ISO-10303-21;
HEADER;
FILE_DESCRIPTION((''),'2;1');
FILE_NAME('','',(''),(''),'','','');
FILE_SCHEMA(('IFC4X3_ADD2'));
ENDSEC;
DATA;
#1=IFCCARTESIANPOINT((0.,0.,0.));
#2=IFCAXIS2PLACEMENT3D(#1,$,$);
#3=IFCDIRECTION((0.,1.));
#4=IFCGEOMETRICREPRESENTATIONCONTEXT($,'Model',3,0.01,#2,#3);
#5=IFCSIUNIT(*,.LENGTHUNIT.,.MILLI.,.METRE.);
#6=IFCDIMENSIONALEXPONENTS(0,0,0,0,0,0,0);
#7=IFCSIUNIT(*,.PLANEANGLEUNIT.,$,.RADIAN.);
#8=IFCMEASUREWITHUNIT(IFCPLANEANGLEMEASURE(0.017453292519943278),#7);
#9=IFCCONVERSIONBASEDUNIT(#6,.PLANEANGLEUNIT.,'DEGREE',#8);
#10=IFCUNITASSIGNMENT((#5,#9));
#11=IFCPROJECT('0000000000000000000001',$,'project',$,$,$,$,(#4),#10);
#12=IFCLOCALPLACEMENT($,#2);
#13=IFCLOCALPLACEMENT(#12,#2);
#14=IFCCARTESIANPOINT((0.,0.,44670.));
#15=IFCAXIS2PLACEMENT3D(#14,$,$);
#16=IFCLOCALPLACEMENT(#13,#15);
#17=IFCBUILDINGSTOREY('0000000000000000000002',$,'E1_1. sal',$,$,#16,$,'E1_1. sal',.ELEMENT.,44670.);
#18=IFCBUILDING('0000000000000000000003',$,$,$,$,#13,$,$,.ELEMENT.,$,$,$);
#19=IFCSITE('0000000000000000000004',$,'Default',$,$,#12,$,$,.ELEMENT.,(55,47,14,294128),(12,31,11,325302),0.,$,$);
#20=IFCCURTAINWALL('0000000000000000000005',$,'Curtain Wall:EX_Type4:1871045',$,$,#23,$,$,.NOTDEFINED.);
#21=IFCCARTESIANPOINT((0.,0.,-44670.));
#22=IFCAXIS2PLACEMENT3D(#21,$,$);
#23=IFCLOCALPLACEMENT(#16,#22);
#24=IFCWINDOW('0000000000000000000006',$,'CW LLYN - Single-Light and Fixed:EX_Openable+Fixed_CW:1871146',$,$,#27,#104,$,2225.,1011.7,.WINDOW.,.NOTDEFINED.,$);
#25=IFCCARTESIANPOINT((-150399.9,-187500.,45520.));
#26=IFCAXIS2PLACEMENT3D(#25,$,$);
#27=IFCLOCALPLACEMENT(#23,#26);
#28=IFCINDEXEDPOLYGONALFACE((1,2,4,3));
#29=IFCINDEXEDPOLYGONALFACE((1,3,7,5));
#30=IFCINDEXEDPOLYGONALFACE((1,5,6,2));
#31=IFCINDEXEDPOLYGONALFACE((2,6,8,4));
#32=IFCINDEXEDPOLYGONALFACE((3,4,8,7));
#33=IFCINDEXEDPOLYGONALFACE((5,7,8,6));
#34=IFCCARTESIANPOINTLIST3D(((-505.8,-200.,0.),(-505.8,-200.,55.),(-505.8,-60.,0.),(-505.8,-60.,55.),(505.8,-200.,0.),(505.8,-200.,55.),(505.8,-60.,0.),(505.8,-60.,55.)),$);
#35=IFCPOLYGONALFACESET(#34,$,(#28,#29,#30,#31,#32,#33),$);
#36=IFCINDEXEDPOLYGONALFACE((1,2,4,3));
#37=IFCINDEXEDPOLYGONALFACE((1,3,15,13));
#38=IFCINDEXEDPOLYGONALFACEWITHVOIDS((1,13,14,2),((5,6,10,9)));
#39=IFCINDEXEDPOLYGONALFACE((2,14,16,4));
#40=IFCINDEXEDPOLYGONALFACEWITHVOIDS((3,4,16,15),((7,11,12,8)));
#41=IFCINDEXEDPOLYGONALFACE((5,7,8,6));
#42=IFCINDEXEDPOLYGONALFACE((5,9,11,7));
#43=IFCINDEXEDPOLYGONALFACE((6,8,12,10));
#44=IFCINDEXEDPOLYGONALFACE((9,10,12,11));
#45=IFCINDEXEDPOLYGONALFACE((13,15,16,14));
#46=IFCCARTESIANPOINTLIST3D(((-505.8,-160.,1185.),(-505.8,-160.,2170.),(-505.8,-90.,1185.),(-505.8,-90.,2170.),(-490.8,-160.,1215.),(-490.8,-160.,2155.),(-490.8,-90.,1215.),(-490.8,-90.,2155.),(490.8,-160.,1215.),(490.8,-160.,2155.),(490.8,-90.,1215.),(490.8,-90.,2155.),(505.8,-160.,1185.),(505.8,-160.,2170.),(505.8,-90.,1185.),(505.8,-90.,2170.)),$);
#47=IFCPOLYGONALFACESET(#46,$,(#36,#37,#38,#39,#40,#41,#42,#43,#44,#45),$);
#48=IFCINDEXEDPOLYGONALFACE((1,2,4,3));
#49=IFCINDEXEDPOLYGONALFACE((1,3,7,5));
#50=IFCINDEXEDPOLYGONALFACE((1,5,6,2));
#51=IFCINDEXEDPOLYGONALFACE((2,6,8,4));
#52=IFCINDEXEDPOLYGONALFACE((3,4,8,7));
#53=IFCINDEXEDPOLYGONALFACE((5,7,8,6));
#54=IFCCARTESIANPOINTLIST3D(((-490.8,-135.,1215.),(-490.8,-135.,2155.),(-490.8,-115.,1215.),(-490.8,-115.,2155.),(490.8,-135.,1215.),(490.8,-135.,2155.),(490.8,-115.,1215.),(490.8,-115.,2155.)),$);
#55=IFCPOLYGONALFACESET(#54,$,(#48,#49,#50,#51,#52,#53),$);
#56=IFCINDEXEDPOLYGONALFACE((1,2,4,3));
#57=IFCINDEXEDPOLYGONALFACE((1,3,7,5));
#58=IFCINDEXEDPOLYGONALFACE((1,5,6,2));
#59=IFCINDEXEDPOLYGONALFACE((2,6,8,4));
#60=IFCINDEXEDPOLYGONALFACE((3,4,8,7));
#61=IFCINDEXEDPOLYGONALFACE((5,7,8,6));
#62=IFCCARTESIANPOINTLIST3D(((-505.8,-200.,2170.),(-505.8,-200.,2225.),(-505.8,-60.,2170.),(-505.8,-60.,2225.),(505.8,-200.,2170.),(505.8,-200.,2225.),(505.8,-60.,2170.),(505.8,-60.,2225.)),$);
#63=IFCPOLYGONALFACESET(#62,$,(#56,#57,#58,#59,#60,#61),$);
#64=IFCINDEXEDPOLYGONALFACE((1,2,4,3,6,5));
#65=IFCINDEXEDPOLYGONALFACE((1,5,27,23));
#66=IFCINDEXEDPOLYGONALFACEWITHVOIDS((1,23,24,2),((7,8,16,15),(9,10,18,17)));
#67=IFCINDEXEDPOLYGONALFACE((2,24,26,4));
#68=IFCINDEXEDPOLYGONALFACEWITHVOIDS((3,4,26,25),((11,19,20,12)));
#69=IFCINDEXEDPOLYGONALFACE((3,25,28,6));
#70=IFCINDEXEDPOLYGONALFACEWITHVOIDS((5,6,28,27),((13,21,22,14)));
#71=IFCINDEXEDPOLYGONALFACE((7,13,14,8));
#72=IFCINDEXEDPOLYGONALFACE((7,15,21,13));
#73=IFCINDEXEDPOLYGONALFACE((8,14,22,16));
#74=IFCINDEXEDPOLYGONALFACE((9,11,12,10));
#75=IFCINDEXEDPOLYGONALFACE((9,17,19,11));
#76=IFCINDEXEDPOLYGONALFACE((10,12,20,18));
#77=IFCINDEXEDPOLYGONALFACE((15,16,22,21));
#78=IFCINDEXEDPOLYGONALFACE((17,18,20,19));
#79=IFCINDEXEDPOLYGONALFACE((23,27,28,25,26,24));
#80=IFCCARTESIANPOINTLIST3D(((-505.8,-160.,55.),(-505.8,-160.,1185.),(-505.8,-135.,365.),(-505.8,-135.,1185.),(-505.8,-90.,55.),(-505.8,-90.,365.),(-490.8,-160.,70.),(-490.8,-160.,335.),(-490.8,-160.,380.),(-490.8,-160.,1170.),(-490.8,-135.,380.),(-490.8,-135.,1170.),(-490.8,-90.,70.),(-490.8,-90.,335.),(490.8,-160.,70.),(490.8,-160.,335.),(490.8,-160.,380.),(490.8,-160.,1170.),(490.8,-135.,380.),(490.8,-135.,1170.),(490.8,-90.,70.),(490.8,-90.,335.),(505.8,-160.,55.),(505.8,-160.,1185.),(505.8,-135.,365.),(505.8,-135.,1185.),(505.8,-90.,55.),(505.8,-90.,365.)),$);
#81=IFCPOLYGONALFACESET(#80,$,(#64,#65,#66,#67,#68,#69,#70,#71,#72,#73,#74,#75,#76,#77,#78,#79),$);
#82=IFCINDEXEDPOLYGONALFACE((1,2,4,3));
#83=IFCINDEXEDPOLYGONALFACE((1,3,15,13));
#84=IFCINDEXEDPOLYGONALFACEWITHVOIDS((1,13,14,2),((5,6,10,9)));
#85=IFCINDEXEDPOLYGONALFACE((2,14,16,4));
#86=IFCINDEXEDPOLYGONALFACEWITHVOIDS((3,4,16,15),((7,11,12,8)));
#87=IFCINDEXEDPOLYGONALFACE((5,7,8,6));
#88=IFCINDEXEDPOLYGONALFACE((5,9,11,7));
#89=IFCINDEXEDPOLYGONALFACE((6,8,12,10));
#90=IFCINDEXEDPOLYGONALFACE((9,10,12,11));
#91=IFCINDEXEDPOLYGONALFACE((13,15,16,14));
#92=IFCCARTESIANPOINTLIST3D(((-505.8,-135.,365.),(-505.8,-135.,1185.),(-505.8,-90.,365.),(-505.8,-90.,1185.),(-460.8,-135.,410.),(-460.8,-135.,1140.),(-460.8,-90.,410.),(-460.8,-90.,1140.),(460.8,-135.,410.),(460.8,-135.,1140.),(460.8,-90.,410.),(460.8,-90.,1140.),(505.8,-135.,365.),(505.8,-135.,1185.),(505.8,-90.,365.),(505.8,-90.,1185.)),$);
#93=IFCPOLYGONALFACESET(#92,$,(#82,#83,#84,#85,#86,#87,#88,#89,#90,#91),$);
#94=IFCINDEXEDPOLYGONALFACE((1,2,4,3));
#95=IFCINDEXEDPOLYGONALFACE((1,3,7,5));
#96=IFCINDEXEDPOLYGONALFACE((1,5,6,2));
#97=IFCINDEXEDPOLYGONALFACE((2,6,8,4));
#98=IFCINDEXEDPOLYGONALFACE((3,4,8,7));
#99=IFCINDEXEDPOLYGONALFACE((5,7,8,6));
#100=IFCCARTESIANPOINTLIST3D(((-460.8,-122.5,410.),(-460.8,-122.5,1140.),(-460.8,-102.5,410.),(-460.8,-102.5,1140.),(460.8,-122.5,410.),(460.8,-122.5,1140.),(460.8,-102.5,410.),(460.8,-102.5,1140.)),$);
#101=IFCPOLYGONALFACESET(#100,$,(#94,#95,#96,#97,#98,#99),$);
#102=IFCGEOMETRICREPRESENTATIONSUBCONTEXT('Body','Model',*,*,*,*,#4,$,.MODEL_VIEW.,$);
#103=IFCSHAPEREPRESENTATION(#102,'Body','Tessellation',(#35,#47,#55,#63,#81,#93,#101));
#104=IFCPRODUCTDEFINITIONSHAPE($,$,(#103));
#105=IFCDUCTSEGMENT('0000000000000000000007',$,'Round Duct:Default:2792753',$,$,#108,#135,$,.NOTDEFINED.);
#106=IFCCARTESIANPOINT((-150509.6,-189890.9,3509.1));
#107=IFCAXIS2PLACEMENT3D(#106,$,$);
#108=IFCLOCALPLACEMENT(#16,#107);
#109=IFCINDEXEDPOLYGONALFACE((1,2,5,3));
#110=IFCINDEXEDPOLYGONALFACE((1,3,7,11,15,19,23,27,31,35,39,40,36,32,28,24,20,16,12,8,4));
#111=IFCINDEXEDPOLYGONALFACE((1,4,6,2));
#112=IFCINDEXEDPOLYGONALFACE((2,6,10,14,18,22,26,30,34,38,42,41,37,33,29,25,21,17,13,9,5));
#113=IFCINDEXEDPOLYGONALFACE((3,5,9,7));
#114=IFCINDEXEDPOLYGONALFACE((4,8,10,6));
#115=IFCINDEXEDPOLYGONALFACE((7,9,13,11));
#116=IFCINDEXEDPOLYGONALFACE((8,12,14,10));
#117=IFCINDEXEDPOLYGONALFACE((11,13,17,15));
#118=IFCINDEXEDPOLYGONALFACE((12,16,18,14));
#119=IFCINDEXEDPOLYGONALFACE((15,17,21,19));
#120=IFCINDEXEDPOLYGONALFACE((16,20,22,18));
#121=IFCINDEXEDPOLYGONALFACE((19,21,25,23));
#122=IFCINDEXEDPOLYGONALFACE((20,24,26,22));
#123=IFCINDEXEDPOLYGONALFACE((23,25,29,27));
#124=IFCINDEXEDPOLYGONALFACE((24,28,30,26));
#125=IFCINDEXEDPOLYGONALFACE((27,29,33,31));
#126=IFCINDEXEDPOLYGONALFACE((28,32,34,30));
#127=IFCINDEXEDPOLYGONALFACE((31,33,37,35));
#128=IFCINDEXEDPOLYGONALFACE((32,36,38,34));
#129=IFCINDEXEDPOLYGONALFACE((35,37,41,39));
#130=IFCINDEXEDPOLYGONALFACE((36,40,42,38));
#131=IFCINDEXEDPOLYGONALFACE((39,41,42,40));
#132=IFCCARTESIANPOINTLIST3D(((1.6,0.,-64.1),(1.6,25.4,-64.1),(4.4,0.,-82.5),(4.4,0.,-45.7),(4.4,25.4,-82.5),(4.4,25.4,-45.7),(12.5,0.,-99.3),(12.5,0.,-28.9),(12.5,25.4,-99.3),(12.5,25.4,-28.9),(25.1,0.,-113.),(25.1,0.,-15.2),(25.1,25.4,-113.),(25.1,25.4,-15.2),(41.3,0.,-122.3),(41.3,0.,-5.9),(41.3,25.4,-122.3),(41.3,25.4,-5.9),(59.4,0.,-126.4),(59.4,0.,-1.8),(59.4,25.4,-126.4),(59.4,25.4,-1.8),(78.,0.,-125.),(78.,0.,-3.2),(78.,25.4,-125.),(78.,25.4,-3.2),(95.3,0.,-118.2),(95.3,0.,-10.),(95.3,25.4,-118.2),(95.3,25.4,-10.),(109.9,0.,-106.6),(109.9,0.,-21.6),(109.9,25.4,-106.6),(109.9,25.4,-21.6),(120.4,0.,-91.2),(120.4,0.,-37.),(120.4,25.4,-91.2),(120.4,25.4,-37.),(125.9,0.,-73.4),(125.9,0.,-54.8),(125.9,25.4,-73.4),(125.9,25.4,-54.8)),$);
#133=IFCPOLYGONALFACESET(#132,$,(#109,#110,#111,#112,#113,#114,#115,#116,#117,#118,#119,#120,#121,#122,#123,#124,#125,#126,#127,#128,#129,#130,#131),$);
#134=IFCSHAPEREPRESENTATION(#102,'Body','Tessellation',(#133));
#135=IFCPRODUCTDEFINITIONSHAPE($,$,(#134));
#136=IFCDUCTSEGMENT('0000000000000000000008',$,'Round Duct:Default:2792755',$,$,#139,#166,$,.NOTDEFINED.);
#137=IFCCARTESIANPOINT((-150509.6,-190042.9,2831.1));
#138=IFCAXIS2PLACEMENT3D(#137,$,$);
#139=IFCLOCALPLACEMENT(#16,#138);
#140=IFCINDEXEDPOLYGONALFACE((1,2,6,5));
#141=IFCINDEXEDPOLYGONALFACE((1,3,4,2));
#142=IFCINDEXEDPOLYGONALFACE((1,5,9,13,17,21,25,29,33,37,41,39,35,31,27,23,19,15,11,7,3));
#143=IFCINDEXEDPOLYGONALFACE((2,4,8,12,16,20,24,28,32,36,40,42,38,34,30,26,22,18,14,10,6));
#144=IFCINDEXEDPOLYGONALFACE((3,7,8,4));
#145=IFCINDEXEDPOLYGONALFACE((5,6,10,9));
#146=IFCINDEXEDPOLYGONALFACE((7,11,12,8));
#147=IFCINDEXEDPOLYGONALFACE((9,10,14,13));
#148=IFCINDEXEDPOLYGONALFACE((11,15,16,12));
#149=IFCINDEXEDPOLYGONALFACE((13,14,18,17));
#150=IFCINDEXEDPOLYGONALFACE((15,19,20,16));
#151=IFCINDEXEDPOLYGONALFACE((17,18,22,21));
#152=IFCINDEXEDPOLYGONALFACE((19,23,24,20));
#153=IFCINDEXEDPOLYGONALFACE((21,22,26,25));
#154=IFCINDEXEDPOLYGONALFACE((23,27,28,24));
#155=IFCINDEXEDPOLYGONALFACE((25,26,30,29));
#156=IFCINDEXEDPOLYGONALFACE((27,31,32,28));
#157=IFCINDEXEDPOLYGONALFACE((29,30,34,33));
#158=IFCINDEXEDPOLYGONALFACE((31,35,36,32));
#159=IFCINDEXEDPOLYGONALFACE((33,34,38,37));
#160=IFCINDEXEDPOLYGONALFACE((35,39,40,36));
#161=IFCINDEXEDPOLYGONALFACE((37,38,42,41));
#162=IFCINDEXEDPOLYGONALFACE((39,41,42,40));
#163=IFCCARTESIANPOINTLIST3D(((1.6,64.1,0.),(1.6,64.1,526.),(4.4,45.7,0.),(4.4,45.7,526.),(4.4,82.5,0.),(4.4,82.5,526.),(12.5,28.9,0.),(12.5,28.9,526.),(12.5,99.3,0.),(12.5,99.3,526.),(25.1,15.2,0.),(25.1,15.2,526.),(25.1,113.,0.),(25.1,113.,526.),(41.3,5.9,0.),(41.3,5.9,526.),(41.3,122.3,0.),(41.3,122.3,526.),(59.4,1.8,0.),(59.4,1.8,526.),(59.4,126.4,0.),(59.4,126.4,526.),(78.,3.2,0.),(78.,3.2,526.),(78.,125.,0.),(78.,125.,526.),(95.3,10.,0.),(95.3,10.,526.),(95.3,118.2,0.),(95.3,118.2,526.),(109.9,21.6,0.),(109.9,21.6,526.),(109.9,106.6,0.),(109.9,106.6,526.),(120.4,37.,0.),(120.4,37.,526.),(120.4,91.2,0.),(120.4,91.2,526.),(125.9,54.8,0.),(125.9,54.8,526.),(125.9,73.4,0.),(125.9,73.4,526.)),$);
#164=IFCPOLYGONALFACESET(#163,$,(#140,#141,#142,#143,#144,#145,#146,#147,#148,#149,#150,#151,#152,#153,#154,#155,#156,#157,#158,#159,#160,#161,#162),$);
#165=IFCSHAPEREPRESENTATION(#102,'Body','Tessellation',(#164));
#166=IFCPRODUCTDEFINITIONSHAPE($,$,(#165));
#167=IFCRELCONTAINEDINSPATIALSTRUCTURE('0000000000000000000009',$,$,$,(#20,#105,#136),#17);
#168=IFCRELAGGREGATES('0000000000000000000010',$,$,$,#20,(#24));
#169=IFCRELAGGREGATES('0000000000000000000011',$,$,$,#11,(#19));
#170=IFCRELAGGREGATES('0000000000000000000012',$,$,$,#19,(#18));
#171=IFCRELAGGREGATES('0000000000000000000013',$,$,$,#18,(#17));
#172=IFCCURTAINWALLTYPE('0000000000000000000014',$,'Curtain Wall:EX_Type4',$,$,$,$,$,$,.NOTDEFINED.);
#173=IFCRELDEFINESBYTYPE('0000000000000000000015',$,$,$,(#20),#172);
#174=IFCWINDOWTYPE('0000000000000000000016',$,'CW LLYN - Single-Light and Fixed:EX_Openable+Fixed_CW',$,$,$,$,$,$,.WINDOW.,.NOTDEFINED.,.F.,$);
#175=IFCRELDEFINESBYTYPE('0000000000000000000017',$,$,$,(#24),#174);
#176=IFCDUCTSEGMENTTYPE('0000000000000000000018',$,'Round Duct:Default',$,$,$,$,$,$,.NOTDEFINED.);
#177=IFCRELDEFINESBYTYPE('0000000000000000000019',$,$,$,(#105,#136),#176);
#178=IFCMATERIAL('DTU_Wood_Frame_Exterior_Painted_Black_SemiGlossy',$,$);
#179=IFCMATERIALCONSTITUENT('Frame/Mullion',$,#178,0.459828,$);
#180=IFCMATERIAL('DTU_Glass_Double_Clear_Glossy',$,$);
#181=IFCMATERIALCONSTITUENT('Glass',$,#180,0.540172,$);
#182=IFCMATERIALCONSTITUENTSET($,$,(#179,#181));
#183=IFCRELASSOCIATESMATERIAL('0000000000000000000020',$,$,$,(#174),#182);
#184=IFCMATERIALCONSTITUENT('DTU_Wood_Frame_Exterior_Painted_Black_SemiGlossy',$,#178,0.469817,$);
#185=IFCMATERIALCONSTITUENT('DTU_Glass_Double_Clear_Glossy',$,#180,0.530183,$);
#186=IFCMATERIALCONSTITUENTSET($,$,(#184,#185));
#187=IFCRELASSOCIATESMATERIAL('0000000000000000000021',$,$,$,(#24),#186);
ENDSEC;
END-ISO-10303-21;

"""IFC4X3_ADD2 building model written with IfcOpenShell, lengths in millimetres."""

from ifc_helpers import new_model, entity, si_unit, converted_unit, direction, frame, frame_2d, origin, origin_2d_with_axis, place, context, subcontext, project, spatial, polyline, rectangle, circle, outline, extrude, source, transform, mapped, material, constituent, constituent_set, type_object, type_shapes, element, aggregate, save


model = new_model("IFC4X3_ADD2")

# Units and contexts
model_context = context("Model", 3, precision=0.01, world=origin(), true_north=direction((0.0, 1.0)))
body_context = subcontext(model_context, "Body", "Model", "MODEL_VIEW")
ifc_project = project(units=[si_unit("LENGTHUNIT", "METRE", prefix="MILLI"), converted_unit("PLANEANGLEUNIT", "DEGREE", entity("IfcPlaneAngleMeasure", 0.017453292519943278), si_unit("PLANEANGLEUNIT", "RADIAN"), dimensions=[0, 0, 0, 0, 0, 0, 0])], contexts=[model_context])

# Site, building, storey
site_placement = place(None, origin())
site = spatial("IfcSite", under=ifc_project, at=site_placement, Name="Default", CompositionType="ELEMENT", RefLatitude=(55, 47, 14, 294128), RefLongitude=(12, 31, 11, 325302), RefElevation=0.0)
building_placement = place(site_placement, origin())
building = spatial("IfcBuilding", under=site, at=building_placement, CompositionType="ELEMENT")
storey_placement = place(building_placement, frame((0.0, 0.0, 44670.0)))
storey = spatial("IfcBuildingStorey", under=building, at=storey_placement, Name="E1_1. sal", LongName="E1_1. sal", CompositionType="ELEMENT", Elevation=44670.0)

# Curtain wall
curtain_wall_type = type_object("IfcCurtainWallType", Name="Curtain Wall:EX_Type4", PredefinedType="NOTDEFINED")
curtain_wall_placement = place(storey_placement, frame((0.0, 0.0, -44670.0)))
curtain_wall = element("IfcCurtainWall", 1, at=curtain_wall_placement, inside=storey, type_object=curtain_wall_type, Name="Curtain Wall:EX_Type4:1871045", PredefinedType="NOTDEFINED")

# Shared definitions
ifc_material_1 = material(Name="DTU_Wood_Frame_Exterior_Painted_Black_SemiGlossy")
ifc_material_2 = material(Name="DTU_Glass_Double_Clear_Glossy")

# Window, openings
ifc_constituent_1 = constituent(ifc_material_1, Name="DTU_Wood_Frame_Exterior_Painted_Black_SemiGlossy", fraction=0.469817)
ifc_constituent_2 = constituent(ifc_material_2, Name="DTU_Glass_Double_Clear_Glossy", fraction=0.530183)
ifc_constituent_set_1 = constituent_set(constituents=[ifc_constituent_1, ifc_constituent_2])
ifc_constituent_3 = constituent(ifc_material_1, Name="Frame/Mullion", fraction=0.459828)
ifc_constituent_4 = constituent(ifc_material_2, Name="Glass", fraction=0.540172)
ifc_constituent_set_2 = constituent_set(constituents=[ifc_constituent_3, ifc_constituent_4])
window_type_1 = type_object("IfcWindowType", Name="CW LLYN - Single-Light and Fixed:EX_Openable+Fixed_CW", ParameterTakesPrecedence=False, PartitioningType="NOTDEFINED", PredefinedType="WINDOW", material=ifc_constituent_set_2)
shared_shape_1 = source(origin(), body_context, "Body", "SweptSolid", [
    extrude(rectangle(XDim=140.0, YDim=1011.7, at=origin_2d_with_axis()), frame((0.0, -130.0, 0.0), z_axis=(0.0, 0.0, 1.0), x_axis=(0.0, -1.0, 0.0)), (0.0, 0.0, 1.0), 55.0),
    extrude(outline(polyline([(-492.5, -505.8), (492.5, -505.8), (492.5, 505.8), (-492.5, 505.8), (-492.5, -505.8)]), holes=[polyline([(477.5, -490.8), (-462.5, -490.8), (-462.5, 490.8), (477.5, 490.8), (477.5, -490.8)])]), frame((0.0, -90.0, 1677.5), z_axis=(0.0, -1.0, 0.0), x_axis=(0.0, 0.0, 1.0)), (0.0, 0.0, 1.0), 70.0),
    extrude(rectangle(XDim=981.7, YDim=20.0, at=frame_2d((0.0, 0.0), x_axis=(1.0, 0.0))), frame((0.0, -125.0, 1215.0), z_axis=(0.0, 0.0, 1.0), x_axis=(-1.0, 0.0, 0.0)), (0.0, 0.0, 1.0), 940.0),
    extrude(rectangle(XDim=981.7, YDim=20.0, at=frame_2d((0.0, 0.0), x_axis=(1.0, 0.0))), frame((0.0, -125.0, 70.0), z_axis=(0.0, 0.0, 1.0), x_axis=(-1.0, 0.0, 0.0)), (0.0, 0.0, 1.0), 265.0),
    extrude(rectangle(XDim=140.0, YDim=1011.7, at=frame_2d((0.0, 0.0), x_axis=(1.0, 0.0))), frame((0.0, -130.0, 2170.0), z_axis=(0.0, 0.0, 1.0), x_axis=(0.0, -1.0, 0.0)), (0.0, 0.0, 1.0), 55.0),
    extrude(outline(polyline([(-38.3, -480.0), (31.7, -480.0), (31.7, 650.0), (6.7, 650.0), (6.7, -170.0), (-38.3, -170.0), (-38.3, -480.0)])), frame((505.8, -128.3, 535.0), z_axis=(-1.0, 0.0, 0.0), x_axis=(0.0, -1.0, 0.0)), (0.0, 0.0, 1.0), 1011.7),
    extrude(outline(polyline([(-410.0, -505.8), (410.0, -505.8), (410.0, 505.8), (-410.0, 505.8), (-410.0, -505.8)]), holes=[polyline([(-365.0, 460.8), (365.0, 460.8), (365.0, -460.8), (-365.0, -460.8), (-365.0, 460.8)])]), frame((0.0, -90.0, 775.0), z_axis=(0.0, -1.0, 0.0), x_axis=(0.0, 0.0, 1.0)), (0.0, 0.0, 1.0), 45.0),
    extrude(rectangle(XDim=921.7, YDim=20.0, at=frame_2d((0.0, 0.0), x_axis=(1.0, 0.0))), frame((0.0, -112.5, 410.0), z_axis=(0.0, 0.0, 1.0), x_axis=(-1.0, 0.0, 0.0)), (0.0, 0.0, 1.0), 730.0),
])
type_shapes(window_type_1, [shared_shape_1])
window_1_placement = place(curtain_wall_placement, frame((-150399.9, -187500.0, 45520.0)))
window_1 = element("IfcWindow", 2, at=window_1_placement, type_object=window_type_1, material=ifc_constituent_set_1, Name="CW LLYN - Single-Light and Fixed:EX_Openable+Fixed_CW:1871146", OverallHeight=2225.0, OverallWidth=1011.7, PartitioningType="NOTDEFINED", PredefinedType="WINDOW", context=body_context, shape_type="MappedRepresentation", body=[
    mapped(shared_shape_1, transform((0.0, 0.0, 0.0), scale=1.0)),
])
opening_1_placement = place(curtain_wall_placement, frame((-150399.9, -187500.0, 90190.0), z_axis=(0.0, 0.0, 1.0), x_axis=(-1.0, 0.0, 0.0)))
opening_1 = element("IfcOpeningElement", 3, at=opening_1_placement, cuts=window_1, PredefinedType="OPENING", context=body_context, shape_type="SweptSolid", body=[
    extrude(rectangle(XDim=265.0, YDim=981.7, at=frame_2d((0.0, 0.0), x_axis=(1.0, 0.0))), frame((0.0, 160.0, -44467.5), z_axis=(0.0, -1.0, 0.0), x_axis=(0.0, 0.0, 1.0)), (0.0, 0.0, 1.0), 70.0),
])
opening_2_placement = place(curtain_wall_placement, frame((-150399.9, -187500.0, 90190.0), z_axis=(0.0, 0.0, 1.0), x_axis=(-1.0, 0.0, 0.0)))
opening_2 = element("IfcOpeningElement", 4, at=opening_2_placement, cuts=window_1, PredefinedType="OPENING", context=body_context, shape_type="SweptSolid", body=[
    extrude(rectangle(XDim=790.0, YDim=981.7, at=frame_2d((0.0, 0.0), x_axis=(1.0, 0.0))), frame((0.0, 135.0, -43895.0), z_axis=(0.0, 1.0, 0.0), x_axis=(0.0, 0.0, 1.0)), (0.0, 0.0, 1.0), 25.0),
])
aggregate(curtain_wall, [window_1, opening_1, opening_2])

# Duct segments
duct_segment_type = type_object("IfcDuctSegmentType", Name="Round Duct:Default", PredefinedType="NOTDEFINED")
duct_segment_1_placement = place(storey_placement, frame((-150509.6, -189890.9, 3509.1)))
element("IfcDuctSegment", 5, at=duct_segment_1_placement, inside=storey, type_object=duct_segment_type, Name="Round Duct:Default:2792753", PredefinedType="NOTDEFINED", context=body_context, shape_type="SweptSolid", body=[
    extrude(circle(Radius=62.5, at=origin_2d_with_axis()), frame((64.1, 0.0, -64.1), z_axis=(0.0, 1.0, 0.0), x_axis=(-1.0, 0.0, 0.0)), (0.0, 0.0, 1.0), 25.4),
])
duct_segment_2_placement = place(storey_placement, frame((-150509.6, -190042.9, 2831.1)))
element("IfcDuctSegment", 6, at=duct_segment_2_placement, inside=storey, type_object=duct_segment_type, Name="Round Duct:Default:2792755", PredefinedType="NOTDEFINED", context=body_context, shape_type="SweptSolid", body=[
    extrude(circle(Radius=62.5, at=origin_2d_with_axis()), frame((64.1, 64.1, 0.0), z_axis=(0.0, 0.0, 1.0), x_axis=(-1.0, 0.0, 0.0)), (0.0, 0.0, 1.0), 526.0),
])

save(model, "model.ifc")
